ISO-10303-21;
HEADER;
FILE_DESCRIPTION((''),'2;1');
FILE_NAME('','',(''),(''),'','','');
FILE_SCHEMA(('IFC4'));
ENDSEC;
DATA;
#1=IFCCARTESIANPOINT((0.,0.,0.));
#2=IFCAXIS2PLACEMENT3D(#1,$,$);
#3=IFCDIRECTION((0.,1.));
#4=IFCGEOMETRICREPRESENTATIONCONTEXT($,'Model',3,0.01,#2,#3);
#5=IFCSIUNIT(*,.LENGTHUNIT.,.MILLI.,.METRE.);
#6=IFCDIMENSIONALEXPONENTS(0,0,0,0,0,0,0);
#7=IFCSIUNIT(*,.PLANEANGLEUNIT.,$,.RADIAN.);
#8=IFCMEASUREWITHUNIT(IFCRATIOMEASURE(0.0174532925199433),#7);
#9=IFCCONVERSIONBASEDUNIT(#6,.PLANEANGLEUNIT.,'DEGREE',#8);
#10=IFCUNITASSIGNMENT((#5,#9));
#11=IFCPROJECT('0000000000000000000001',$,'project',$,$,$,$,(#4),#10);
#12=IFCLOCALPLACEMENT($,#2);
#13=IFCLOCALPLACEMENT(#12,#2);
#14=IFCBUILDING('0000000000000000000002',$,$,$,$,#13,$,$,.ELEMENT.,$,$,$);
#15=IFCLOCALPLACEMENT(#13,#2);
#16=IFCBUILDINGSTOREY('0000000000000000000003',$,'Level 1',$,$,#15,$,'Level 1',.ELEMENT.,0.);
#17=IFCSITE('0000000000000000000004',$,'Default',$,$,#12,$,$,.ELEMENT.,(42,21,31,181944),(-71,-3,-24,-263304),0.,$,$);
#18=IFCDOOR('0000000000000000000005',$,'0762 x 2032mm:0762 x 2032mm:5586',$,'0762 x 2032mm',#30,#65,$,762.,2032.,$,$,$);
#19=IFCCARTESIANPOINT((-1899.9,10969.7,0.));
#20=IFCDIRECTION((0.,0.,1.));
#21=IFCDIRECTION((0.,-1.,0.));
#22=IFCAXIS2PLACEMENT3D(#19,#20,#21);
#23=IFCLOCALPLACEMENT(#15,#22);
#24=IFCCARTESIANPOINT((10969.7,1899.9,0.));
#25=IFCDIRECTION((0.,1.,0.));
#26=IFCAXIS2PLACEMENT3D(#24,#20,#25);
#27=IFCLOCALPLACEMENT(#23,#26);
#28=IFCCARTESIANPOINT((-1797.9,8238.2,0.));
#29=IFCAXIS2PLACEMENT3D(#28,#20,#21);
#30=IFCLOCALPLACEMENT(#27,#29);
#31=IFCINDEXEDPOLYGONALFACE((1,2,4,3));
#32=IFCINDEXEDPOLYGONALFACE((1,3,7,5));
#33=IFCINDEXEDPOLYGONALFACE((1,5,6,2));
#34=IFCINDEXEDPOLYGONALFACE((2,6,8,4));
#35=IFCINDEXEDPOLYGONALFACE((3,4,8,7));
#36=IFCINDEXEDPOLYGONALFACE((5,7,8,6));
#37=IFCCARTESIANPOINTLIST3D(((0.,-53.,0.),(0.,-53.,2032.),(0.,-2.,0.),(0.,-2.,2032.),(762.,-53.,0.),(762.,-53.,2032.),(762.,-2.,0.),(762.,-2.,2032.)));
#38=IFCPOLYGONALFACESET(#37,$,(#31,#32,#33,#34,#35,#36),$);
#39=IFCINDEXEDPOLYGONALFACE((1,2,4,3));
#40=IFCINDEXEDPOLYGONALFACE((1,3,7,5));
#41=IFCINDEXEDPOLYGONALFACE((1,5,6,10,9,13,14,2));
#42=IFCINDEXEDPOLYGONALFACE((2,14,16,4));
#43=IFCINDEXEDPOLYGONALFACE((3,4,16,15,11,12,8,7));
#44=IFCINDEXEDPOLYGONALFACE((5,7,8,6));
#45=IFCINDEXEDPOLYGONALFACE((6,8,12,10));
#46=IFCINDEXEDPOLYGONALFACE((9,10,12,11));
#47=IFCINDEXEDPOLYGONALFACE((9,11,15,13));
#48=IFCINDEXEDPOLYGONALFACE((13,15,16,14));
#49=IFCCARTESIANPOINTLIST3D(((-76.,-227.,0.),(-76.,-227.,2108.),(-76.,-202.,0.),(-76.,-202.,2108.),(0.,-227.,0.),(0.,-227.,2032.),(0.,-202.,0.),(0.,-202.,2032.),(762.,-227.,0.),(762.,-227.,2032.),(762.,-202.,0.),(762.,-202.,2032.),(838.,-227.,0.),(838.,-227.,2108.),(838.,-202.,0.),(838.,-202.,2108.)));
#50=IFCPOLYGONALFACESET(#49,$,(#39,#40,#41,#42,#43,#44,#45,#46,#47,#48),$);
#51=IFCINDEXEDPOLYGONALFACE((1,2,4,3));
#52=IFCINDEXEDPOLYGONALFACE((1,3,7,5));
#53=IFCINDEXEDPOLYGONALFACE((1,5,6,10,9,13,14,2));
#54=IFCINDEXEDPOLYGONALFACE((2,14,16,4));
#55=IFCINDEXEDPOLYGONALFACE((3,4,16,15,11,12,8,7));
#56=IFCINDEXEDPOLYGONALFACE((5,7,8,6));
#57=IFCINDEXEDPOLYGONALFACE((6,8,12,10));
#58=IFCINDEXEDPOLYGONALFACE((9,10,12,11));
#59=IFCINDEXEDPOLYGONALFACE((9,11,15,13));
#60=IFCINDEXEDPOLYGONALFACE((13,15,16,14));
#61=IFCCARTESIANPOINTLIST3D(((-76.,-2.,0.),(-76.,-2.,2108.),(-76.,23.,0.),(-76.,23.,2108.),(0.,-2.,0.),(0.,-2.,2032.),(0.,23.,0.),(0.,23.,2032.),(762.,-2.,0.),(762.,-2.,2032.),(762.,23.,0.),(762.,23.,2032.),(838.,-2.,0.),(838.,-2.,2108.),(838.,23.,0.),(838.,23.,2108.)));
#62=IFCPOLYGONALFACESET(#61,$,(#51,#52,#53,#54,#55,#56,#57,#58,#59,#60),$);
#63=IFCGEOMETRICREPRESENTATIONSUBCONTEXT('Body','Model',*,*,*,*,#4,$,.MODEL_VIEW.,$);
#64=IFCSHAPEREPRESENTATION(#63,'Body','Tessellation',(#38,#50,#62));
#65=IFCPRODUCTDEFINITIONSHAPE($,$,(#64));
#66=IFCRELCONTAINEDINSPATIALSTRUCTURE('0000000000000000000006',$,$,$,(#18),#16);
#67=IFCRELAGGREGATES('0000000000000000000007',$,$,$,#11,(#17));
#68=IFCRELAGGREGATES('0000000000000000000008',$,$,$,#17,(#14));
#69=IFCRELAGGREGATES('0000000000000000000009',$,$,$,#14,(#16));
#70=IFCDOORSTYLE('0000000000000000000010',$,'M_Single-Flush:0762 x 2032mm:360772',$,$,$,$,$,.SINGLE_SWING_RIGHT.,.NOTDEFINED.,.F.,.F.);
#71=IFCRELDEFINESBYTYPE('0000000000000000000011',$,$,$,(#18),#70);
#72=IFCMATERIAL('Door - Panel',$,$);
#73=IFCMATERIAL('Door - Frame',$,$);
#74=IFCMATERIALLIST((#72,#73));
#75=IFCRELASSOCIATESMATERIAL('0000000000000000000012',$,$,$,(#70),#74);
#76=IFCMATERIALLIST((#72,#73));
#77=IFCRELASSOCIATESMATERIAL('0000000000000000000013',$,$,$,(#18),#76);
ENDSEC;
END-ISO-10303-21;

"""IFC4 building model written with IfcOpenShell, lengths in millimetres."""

from ifc_helpers import new_model, entity, si_unit, converted_unit, direction, frame, frame_2d, origin, place, context, subcontext, project, spatial, polyline, rectangle, outline, extrude, source, transform, mapped, material, material_list, type_object, type_shapes, element, save


model = new_model("IFC4")

# Units and contexts
model_context = context("Model", 3, precision=0.01, world=origin(), true_north=direction((0.0, 1.0)))
body_context = subcontext(model_context, "Body", "Model", "MODEL_VIEW")
ifc_project = project(units=[si_unit("LENGTHUNIT", "METRE", prefix="MILLI"), converted_unit("PLANEANGLEUNIT", "DEGREE", entity("IfcRatioMeasure", 0.0174532925199433), si_unit("PLANEANGLEUNIT", "RADIAN"), dimensions=[0, 0, 0, 0, 0, 0, 0])], contexts=[model_context])

# Site, building, storey
site_placement = place(None, origin())
site = spatial("IfcSite", under=ifc_project, at=site_placement, Name="Default", CompositionType="ELEMENT", RefLatitude=(42, 21, 31, 181944), RefLongitude=(-71, -3, -24, -263304), RefElevation=0.0)
building_placement = place(site_placement, origin())
building = spatial("IfcBuilding", under=site, at=building_placement, CompositionType="ELEMENT")
storey_placement = place(building_placement, origin())
storey = spatial("IfcBuildingStorey", under=building, at=storey_placement, Name="Level 1", LongName="Level 1", CompositionType="ELEMENT", Elevation=0.0)

# Shared definitions
placement_1 = place(storey_placement, frame((-1899.9, 10969.7, 0.0), z_axis=(0.0, 0.0, 1.0), x_axis=(0.0, -1.0, 0.0)))

# Door
ifc_material_1 = material(Name="Door - Panel")
ifc_material_2 = material(Name="Door - Frame")
ifc_material_list_1 = material_list([ifc_material_1, ifc_material_2])
ifc_material_list_2 = material_list([ifc_material_1, ifc_material_2])
door_style = type_object("IfcDoorStyle", Name="M_Single-Flush:0762 x 2032mm:360772", ConstructionType="NOTDEFINED", OperationType="SINGLE_SWING_RIGHT", ParameterTakesPrecedence=False, Sizeable=False, material=ifc_material_list_2)
shared_shape = source(origin(), body_context, "Body", "SweptSolid", [
    extrude(rectangle(XDim=762.0, YDim=51.0, at=frame_2d((0.0, 0.0), x_axis=(1.0, 0.0))), frame((381.0, -27.5, 0.0), z_axis=(0.0, 0.0, 1.0), x_axis=(-1.0, 0.0, 0.0)), (0.0, 0.0, 1.0), 2032.0),
    extrude(outline(polyline([(-457.0, -1035.0), (-381.0, -1035.0), (-381.0, 997.0), (381.0, 997.0), (381.0, -1035.0), (457.0, -1035.0), (457.0, 1073.0), (-457.0, 1073.0), (-457.0, -1035.0)])), frame((381.0, -227.0, 1035.0), z_axis=(0.0, 1.0, 0.0), x_axis=(-1.0, 0.0, 0.0)), (0.0, 0.0, 1.0), 25.0),
    extrude(outline(polyline([(-1073.0, -457.0), (1035.0, -457.0), (1035.0, -381.0), (-997.0, -381.0), (-997.0, 381.0), (1035.0, 381.0), (1035.0, 457.0), (-1073.0, 457.0), (-1073.0, -457.0)])), frame((381.0, -2.0, 1035.0), z_axis=(0.0, 1.0, 0.0), x_axis=(0.0, 0.0, -1.0)), (0.0, 0.0, 1.0), 25.0),
])
type_shapes(door_style, [shared_shape])
placement_2 = place(placement_1, frame((10969.7, 1899.9, 0.0), z_axis=(0.0, 0.0, 1.0), x_axis=(0.0, 1.0, 0.0)))
door_placement = place(placement_2, frame((-1797.9, 8238.2, 0.0), z_axis=(0.0, 0.0, 1.0), x_axis=(0.0, -1.0, 0.0)))
element("IfcDoor", 1, at=door_placement, inside=storey, type_object=door_style, material=ifc_material_list_1, Name="0762 x 2032mm:0762 x 2032mm:5586", ObjectType="0762 x 2032mm", OverallHeight=762.0, OverallWidth=2032.0, context=body_context, shape_type="MappedRepresentation", body=[
    mapped(shared_shape, transform((0.0, 0.0, 0.0), scale=1.0)),
])

save(model, "model.ifc")
